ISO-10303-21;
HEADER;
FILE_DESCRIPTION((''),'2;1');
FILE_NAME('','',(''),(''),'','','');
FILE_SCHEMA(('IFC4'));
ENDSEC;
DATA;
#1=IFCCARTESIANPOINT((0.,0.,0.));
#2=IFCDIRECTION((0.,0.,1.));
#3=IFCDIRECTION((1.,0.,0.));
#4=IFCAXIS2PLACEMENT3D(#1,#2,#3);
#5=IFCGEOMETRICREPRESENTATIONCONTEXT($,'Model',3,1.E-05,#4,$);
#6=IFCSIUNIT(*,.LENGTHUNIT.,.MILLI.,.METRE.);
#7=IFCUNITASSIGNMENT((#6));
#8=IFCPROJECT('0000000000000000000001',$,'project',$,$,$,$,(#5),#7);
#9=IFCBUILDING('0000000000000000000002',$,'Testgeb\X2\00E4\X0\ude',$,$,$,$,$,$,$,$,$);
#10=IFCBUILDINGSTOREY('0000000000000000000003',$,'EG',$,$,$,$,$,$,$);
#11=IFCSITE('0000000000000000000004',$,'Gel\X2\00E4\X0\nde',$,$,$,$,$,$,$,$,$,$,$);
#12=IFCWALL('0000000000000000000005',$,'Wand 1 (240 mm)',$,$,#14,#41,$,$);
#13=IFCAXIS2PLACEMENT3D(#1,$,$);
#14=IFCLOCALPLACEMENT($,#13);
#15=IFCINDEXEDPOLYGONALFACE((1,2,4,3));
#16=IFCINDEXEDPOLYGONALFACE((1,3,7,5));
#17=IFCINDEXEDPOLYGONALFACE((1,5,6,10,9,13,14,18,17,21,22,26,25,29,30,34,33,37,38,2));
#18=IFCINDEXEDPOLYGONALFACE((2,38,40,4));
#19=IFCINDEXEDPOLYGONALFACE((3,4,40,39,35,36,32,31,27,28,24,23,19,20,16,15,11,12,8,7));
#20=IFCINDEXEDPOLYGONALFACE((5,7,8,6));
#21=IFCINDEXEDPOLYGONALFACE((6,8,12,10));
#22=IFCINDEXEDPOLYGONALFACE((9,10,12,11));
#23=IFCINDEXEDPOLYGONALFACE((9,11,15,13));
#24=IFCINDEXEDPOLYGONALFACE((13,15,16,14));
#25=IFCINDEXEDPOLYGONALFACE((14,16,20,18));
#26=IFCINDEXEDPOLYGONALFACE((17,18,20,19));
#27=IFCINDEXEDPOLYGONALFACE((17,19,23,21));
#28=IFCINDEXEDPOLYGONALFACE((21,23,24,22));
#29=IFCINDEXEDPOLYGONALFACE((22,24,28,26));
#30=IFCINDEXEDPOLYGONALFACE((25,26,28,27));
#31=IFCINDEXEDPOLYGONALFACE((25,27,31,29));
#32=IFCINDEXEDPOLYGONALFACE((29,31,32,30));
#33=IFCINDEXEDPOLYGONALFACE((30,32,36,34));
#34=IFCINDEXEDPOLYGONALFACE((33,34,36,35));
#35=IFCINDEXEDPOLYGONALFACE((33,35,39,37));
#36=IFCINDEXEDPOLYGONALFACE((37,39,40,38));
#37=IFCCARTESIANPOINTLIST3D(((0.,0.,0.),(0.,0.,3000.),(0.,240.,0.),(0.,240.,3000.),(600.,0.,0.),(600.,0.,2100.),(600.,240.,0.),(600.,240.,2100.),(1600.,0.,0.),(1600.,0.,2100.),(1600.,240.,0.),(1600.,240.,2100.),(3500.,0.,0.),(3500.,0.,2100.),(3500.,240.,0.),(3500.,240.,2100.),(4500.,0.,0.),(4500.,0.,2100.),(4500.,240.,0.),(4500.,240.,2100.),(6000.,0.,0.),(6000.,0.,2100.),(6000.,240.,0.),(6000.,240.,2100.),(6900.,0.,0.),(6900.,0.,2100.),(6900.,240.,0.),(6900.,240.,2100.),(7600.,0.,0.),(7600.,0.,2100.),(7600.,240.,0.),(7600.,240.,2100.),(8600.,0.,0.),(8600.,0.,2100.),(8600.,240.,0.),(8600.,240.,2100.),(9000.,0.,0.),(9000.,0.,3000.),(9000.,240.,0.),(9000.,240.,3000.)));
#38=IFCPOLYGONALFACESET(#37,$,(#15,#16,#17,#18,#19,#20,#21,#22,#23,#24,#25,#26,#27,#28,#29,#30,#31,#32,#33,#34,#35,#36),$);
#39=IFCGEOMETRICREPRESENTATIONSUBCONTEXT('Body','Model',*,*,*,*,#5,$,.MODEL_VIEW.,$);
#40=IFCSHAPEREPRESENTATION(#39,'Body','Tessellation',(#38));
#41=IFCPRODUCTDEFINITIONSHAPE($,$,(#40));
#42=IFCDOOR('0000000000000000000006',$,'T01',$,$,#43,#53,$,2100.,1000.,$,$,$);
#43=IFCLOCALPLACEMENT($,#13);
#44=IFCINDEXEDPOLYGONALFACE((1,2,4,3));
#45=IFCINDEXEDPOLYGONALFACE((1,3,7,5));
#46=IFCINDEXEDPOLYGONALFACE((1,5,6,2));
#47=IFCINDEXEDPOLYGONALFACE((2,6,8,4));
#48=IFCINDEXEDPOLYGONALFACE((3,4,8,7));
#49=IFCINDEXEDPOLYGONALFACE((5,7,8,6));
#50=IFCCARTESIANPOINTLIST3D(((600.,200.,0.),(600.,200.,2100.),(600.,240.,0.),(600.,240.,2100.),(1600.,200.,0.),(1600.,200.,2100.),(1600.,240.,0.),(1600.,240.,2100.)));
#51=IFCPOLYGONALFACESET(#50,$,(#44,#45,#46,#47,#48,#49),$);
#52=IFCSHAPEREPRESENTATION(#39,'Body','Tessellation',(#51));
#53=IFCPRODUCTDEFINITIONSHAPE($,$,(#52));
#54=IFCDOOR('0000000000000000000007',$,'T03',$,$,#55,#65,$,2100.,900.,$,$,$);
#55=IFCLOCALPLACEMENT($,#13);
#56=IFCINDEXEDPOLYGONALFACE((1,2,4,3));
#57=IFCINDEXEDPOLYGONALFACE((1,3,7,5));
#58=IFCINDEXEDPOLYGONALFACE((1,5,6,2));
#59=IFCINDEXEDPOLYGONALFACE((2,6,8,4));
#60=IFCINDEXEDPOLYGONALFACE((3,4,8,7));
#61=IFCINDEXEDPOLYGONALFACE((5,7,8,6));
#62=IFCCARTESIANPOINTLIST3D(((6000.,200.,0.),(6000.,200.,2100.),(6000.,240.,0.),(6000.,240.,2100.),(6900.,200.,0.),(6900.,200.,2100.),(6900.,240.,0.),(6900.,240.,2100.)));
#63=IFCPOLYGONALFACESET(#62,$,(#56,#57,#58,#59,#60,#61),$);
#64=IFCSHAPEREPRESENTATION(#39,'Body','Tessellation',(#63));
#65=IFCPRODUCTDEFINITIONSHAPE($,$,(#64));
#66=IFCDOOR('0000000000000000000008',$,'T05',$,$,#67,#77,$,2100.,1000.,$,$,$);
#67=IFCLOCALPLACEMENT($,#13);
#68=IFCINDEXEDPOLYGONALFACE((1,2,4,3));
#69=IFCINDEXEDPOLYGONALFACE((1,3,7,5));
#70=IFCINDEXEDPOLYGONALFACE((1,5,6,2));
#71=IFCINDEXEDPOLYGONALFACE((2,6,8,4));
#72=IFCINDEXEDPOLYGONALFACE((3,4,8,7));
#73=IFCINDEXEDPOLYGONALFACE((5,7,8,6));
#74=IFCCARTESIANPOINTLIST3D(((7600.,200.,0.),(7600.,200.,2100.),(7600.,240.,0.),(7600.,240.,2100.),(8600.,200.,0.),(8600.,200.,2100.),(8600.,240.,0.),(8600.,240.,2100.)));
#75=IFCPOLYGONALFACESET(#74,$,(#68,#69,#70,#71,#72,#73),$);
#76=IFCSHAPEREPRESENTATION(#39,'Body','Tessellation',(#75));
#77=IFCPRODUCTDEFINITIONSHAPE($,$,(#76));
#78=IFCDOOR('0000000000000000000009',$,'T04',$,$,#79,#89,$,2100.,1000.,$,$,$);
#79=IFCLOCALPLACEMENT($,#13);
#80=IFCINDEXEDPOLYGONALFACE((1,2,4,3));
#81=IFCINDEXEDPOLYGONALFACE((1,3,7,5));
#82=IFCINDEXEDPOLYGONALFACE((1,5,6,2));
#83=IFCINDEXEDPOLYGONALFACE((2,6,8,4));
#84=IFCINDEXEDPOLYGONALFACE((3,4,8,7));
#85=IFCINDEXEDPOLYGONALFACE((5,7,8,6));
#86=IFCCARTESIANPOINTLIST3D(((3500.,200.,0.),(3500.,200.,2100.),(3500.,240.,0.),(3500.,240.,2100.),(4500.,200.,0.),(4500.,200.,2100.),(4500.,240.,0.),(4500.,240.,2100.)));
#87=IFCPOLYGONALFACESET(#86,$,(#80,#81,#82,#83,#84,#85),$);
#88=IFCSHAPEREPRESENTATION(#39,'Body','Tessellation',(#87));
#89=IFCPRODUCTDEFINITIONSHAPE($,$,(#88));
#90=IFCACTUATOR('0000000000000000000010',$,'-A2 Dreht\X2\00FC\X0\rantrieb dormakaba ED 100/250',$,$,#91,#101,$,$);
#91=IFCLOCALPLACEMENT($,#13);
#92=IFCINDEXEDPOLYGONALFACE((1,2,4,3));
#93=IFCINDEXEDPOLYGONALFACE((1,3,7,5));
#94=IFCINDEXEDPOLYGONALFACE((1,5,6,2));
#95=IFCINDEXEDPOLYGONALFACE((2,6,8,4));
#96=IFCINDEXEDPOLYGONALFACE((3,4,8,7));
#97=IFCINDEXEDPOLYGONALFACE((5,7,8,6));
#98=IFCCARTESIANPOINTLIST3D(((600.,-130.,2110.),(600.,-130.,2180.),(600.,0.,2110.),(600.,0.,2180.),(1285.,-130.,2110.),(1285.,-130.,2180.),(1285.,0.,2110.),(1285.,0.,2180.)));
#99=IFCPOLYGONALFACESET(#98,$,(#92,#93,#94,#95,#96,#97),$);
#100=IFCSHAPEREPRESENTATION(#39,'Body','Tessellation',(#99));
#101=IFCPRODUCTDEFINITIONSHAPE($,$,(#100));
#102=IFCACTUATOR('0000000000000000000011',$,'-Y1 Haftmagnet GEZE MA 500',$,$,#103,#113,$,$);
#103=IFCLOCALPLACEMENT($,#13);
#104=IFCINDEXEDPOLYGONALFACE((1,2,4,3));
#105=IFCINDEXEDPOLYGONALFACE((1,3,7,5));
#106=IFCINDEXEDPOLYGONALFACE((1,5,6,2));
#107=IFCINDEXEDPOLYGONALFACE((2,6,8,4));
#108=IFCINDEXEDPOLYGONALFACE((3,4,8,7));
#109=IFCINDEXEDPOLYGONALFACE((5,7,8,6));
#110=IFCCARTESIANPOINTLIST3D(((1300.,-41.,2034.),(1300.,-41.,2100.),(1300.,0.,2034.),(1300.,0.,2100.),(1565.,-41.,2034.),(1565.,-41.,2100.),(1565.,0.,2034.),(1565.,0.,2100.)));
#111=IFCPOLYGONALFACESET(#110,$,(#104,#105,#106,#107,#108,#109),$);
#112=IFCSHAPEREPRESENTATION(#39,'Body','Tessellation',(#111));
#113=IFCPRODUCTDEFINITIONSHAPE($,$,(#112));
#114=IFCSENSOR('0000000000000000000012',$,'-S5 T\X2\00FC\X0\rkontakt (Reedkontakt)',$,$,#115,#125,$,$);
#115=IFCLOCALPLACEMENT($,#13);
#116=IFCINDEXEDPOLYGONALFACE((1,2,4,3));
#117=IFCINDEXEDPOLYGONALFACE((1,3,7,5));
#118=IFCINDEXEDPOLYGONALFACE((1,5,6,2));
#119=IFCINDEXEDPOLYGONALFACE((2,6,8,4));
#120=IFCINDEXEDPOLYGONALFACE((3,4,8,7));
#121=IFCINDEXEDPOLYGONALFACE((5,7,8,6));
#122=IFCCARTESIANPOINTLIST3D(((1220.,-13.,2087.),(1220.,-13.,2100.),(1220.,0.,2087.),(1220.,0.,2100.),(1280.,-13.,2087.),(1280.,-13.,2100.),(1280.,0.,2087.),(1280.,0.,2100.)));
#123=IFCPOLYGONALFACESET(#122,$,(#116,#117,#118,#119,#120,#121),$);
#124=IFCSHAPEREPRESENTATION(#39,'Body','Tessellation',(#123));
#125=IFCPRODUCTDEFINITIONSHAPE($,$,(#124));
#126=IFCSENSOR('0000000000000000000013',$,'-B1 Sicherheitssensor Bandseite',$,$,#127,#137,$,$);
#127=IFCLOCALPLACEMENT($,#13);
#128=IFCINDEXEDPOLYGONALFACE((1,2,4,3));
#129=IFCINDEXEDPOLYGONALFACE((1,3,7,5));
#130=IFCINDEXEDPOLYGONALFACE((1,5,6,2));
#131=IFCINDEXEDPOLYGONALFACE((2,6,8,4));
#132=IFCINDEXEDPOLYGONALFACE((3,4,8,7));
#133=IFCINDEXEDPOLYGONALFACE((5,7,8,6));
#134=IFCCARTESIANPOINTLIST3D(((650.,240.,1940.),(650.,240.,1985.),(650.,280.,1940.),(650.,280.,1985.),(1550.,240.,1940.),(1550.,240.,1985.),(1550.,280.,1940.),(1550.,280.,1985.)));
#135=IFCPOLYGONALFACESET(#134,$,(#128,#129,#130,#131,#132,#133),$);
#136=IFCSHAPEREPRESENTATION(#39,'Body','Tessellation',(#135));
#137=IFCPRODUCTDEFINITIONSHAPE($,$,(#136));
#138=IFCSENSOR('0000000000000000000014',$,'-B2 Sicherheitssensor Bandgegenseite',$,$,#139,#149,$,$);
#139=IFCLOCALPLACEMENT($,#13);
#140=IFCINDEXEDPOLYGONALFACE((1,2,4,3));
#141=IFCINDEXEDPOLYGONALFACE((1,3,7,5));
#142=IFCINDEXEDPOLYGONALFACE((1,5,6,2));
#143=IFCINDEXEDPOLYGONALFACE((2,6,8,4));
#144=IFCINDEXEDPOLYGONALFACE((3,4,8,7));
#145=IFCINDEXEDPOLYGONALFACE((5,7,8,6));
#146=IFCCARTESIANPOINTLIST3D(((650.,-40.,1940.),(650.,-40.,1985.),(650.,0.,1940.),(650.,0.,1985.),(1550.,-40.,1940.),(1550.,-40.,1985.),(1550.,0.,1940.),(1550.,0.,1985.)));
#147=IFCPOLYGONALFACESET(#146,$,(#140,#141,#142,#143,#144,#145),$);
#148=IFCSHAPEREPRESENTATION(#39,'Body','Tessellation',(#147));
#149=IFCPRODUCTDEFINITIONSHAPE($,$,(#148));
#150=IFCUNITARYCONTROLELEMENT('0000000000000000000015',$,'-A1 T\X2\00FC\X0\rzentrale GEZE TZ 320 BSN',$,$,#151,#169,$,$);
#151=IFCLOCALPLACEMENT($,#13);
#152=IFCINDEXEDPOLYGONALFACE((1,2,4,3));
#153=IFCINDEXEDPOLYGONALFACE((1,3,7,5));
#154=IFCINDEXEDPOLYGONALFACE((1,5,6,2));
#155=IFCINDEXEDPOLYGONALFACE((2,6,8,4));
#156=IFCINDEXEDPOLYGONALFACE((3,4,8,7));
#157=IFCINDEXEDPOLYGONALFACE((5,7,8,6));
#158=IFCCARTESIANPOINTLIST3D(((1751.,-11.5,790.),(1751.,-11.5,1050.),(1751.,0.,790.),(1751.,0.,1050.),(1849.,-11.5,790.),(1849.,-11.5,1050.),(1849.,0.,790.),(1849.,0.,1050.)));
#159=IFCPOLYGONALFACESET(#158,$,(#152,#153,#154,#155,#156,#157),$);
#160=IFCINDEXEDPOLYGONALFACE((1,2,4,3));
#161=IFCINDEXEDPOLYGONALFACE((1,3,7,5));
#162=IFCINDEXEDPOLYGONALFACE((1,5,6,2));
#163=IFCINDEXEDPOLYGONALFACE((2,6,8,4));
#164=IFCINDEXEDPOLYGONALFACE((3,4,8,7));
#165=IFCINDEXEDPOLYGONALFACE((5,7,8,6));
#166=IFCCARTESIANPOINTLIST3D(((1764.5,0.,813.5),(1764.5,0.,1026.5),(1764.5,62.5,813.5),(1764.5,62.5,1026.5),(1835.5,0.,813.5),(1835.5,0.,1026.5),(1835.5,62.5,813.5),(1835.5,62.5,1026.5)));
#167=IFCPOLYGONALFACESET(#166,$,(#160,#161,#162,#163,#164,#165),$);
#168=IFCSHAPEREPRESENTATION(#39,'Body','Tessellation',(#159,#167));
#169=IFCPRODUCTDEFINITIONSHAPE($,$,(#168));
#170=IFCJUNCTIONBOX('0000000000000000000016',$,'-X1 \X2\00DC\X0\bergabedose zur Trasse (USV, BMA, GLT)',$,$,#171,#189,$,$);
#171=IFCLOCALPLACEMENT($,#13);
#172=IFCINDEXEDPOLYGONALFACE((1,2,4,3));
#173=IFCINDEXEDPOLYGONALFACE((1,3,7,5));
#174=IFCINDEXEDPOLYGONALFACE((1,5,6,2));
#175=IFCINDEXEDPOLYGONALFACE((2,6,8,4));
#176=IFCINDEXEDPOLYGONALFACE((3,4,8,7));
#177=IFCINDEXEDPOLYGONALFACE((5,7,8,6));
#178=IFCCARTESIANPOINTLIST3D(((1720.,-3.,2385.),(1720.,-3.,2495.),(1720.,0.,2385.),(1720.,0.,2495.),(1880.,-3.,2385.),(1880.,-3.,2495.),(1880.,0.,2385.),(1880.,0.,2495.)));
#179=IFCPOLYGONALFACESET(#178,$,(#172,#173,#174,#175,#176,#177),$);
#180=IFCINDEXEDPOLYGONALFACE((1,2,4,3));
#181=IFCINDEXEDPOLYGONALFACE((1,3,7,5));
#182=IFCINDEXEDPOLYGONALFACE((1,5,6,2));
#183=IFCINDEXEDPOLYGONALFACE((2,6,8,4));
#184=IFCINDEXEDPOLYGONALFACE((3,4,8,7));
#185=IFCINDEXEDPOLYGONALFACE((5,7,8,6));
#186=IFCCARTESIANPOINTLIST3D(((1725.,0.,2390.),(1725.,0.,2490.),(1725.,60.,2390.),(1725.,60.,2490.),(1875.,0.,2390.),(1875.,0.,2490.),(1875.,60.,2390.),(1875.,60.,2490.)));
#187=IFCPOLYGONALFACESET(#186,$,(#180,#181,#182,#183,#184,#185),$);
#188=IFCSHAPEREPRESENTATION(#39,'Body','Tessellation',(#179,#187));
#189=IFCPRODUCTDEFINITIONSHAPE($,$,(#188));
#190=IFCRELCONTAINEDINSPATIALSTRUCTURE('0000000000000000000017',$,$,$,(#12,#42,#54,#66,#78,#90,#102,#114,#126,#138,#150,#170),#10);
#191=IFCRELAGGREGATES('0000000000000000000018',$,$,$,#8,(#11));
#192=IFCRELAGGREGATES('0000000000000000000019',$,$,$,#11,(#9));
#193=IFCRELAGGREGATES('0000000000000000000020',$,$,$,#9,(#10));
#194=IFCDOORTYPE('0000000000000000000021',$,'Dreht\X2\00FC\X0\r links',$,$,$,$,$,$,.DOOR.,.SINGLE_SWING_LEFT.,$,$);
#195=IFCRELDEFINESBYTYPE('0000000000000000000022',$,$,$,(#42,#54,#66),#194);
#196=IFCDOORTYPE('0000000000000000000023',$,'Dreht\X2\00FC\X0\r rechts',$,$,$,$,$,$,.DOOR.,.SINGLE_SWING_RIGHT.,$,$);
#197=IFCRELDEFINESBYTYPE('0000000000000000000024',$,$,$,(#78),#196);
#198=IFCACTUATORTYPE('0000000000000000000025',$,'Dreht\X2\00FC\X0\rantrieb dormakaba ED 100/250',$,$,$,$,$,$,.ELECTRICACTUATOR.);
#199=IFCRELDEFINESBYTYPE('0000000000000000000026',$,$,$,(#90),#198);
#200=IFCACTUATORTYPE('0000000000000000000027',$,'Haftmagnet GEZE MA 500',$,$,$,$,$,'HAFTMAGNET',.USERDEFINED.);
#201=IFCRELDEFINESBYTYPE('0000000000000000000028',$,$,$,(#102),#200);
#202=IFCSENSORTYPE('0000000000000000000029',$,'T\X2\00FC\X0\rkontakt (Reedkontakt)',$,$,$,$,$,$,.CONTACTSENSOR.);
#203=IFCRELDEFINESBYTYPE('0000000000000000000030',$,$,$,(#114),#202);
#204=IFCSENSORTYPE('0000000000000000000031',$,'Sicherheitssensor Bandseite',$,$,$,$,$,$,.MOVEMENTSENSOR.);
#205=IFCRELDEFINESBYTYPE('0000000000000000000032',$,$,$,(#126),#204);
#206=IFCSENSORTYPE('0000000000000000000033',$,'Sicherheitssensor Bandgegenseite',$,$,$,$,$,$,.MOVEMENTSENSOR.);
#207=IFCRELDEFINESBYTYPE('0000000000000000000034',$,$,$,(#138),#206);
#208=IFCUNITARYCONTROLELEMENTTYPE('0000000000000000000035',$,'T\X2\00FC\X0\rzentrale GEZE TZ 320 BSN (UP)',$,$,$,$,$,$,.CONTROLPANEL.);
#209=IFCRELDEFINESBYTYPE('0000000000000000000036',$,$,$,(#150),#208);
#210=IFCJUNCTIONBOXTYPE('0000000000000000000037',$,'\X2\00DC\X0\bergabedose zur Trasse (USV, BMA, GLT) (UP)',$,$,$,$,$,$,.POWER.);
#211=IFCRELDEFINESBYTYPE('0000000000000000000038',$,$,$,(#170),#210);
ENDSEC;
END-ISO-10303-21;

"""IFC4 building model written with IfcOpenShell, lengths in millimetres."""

from ifc_helpers import new_model, si_unit, frame, frame_2d, origin_with_axes, place, context, subcontext, project, spatial, rectangle, extrude, type_object, element, fill, save


model = new_model("IFC4")

# Units and contexts
model_context = context("Model", 3, precision=1e-05, world=origin_with_axes())
body_context = subcontext(model_context, "Body", "Model", "MODEL_VIEW")
ifc_project = project(units=[si_unit("LENGTHUNIT", "METRE", prefix="MILLI")], contexts=[model_context])

# Site, building, storey
site = spatial("IfcSite", under=ifc_project, Name="Gelände")
building = spatial("IfcBuilding", under=site, Name="Testgebäude")
storey = spatial("IfcBuildingStorey", under=building, Name="EG")

# Wall, openings, doors
wall_placement = place(None, origin_with_axes())
wall = element("IfcWall", 1, at=wall_placement, inside=storey, Name="Wand 1 (240 mm)", context=body_context, shape_type="SweptSolid", body=[
    extrude(rectangle(XDim=9000.0, YDim=240.0, at=frame_2d((4500.0, 120.0))), None, (0.0, 0.0, 1.0), 3000.0),
])
opening_1_placement = place(None, frame((600.0, 0.0, 0.0), z_axis=(0.0, 0.0, 1.0), x_axis=(1.0, 0.0, 0.0)))
opening_1 = element("IfcOpeningElement", 2, at=opening_1_placement, cuts=wall, context=body_context, shape_type="SweptSolid", body=[
    extrude(rectangle(XDim=1000.0, YDim=240.0, at=frame_2d((500.0, 120.0))), None, (0.0, 0.0, 1.0), 2100.0),
])
opening_2_placement = place(None, frame((3500.0, 0.0, 0.0), z_axis=(0.0, 0.0, 1.0), x_axis=(1.0, 0.0, 0.0)))
opening_2 = element("IfcOpeningElement", 3, at=opening_2_placement, cuts=wall, context=body_context, shape_type="SweptSolid", body=[
    extrude(rectangle(XDim=1000.0, YDim=240.0, at=frame_2d((500.0, 120.0))), None, (0.0, 0.0, 1.0), 2100.0),
])
opening_3_placement = place(None, frame((6000.0, 0.0, 0.0), z_axis=(0.0, 0.0, 1.0), x_axis=(1.0, 0.0, 0.0)))
opening_3 = element("IfcOpeningElement", 4, at=opening_3_placement, cuts=wall, context=body_context, shape_type="SweptSolid", body=[
    extrude(rectangle(XDim=900.0, YDim=240.0, at=frame_2d((450.0, 120.0))), None, (0.0, 0.0, 1.0), 2100.0),
])
opening_4_placement = place(None, frame((7600.0, 0.0, 0.0), z_axis=(0.0, 0.0, 1.0), x_axis=(1.0, 0.0, 0.0)))
opening_4 = element("IfcOpeningElement", 5, at=opening_4_placement, cuts=wall, context=body_context, shape_type="SweptSolid", body=[
    extrude(rectangle(XDim=1000.0, YDim=240.0, at=frame_2d((500.0, 120.0))), None, (0.0, 0.0, 1.0), 2100.0),
])
door_type_1 = type_object("IfcDoorType", Name="Drehtür links", OperationType="SINGLE_SWING_LEFT", PredefinedType="DOOR")
door_1_placement = place(opening_1_placement, origin_with_axes())
door_1 = element("IfcDoor", 6, at=door_1_placement, inside=storey, type_object=door_type_1, Name="T01", OverallHeight=2100.0, OverallWidth=1000.0, context=body_context, shape_type="SweptSolid", body=[
    extrude(rectangle(XDim=1000.0, YDim=40.0, at=frame_2d((500.0, 20.0))), frame((0.0, 200.0, 0.0)), (0.0, 0.0, 1.0), 2100.0),
])
fill(opening_1, door_1)
door_2_placement = place(opening_3_placement, origin_with_axes())
door_2 = element("IfcDoor", 7, at=door_2_placement, inside=storey, type_object=door_type_1, Name="T03", OverallHeight=2100.0, OverallWidth=900.0, context=body_context, shape_type="SweptSolid", body=[
    extrude(rectangle(XDim=900.0, YDim=40.0, at=frame_2d((450.0, 20.0))), frame((0.0, 200.0, 0.0)), (0.0, 0.0, 1.0), 2100.0),
])
fill(opening_3, door_2)
door_3_placement = place(opening_4_placement, origin_with_axes())
door_3 = element("IfcDoor", 8, at=door_3_placement, inside=storey, type_object=door_type_1, Name="T05", OverallHeight=2100.0, OverallWidth=1000.0, context=body_context, shape_type="SweptSolid", body=[
    extrude(rectangle(XDim=1000.0, YDim=40.0, at=frame_2d((500.0, 20.0))), frame((0.0, 200.0, 0.0)), (0.0, 0.0, 1.0), 2100.0),
])
fill(opening_4, door_3)
door_type_2 = type_object("IfcDoorType", Name="Drehtür rechts", OperationType="SINGLE_SWING_RIGHT", PredefinedType="DOOR")
door_4_placement = place(opening_2_placement, origin_with_axes())
door_4 = element("IfcDoor", 9, at=door_4_placement, inside=storey, type_object=door_type_2, Name="T04", OverallHeight=2100.0, OverallWidth=1000.0, context=body_context, shape_type="SweptSolid", body=[
    extrude(rectangle(XDim=1000.0, YDim=40.0, at=frame_2d((500.0, 20.0))), frame((0.0, 200.0, 0.0)), (0.0, 0.0, 1.0), 2100.0),
])
fill(opening_2, door_4)

# Actuators
actuator_type_1 = type_object("IfcActuatorType", Name="Drehtürantrieb dormakaba ED 100/250", PredefinedType="ELECTRICACTUATOR")
actuator_1_placement = place(None, frame((600.0, -130.0, 2110.0), z_axis=(0.0, 0.0, 1.0), x_axis=(1.0, 0.0, 0.0)))
element("IfcActuator", 10, at=actuator_1_placement, inside=storey, type_object=actuator_type_1, Name="-A2 Drehtürantrieb dormakaba ED 100/250", context=body_context, shape_type="SweptSolid", body=[
    extrude(rectangle(XDim=685.0, YDim=130.0, at=frame_2d((342.5, 65.0))), None, (0.0, 0.0, 1.0), 70.0),
])
actuator_type_2 = type_object("IfcActuatorType", Name="Haftmagnet GEZE MA 500", ElementType="HAFTMAGNET", PredefinedType="USERDEFINED")
actuator_2_placement = place(None, frame((1300.0, -41.0, 2034.0), z_axis=(0.0, 0.0, 1.0), x_axis=(1.0, 0.0, 0.0)))
element("IfcActuator", 11, at=actuator_2_placement, inside=storey, type_object=actuator_type_2, Name="-Y1 Haftmagnet GEZE MA 500", context=body_context, shape_type="SweptSolid", body=[
    extrude(rectangle(XDim=265.0, YDim=41.0, at=frame_2d((132.5, 20.5))), None, (0.0, 0.0, 1.0), 66.0),
])

# Sensors
sensor_type_1 = type_object("IfcSensorType", Name="Türkontakt (Reedkontakt)", PredefinedType="CONTACTSENSOR")
sensor_1_placement = place(None, frame((1220.0, -13.0, 2087.0), z_axis=(0.0, 0.0, 1.0), x_axis=(1.0, 0.0, 0.0)))
element("IfcSensor", 12, at=sensor_1_placement, inside=storey, type_object=sensor_type_1, Name="-S5 Türkontakt (Reedkontakt)", context=body_context, shape_type="SweptSolid", body=[
    extrude(rectangle(XDim=60.0, YDim=13.0, at=frame_2d((30.0, 6.5))), None, (0.0, 0.0, 1.0), 13.0),
])
sensor_type_2 = type_object("IfcSensorType", Name="Sicherheitssensor Bandseite", PredefinedType="MOVEMENTSENSOR")
sensor_2_placement = place(None, frame((650.0, 240.0, 1940.0), z_axis=(0.0, 0.0, 1.0), x_axis=(1.0, 0.0, 0.0)))
element("IfcSensor", 13, at=sensor_2_placement, inside=storey, type_object=sensor_type_2, Name="-B1 Sicherheitssensor Bandseite", context=body_context, shape_type="SweptSolid", body=[
    extrude(rectangle(XDim=900.0, YDim=40.0, at=frame_2d((450.0, 20.0))), None, (0.0, 0.0, 1.0), 45.0),
])
sensor_type_3 = type_object("IfcSensorType", Name="Sicherheitssensor Bandgegenseite", PredefinedType="MOVEMENTSENSOR")
sensor_3_placement = place(None, frame((650.0, -40.0, 1940.0), z_axis=(0.0, 0.0, 1.0), x_axis=(1.0, 0.0, 0.0)))
element("IfcSensor", 14, at=sensor_3_placement, inside=storey, type_object=sensor_type_3, Name="-B2 Sicherheitssensor Bandgegenseite", context=body_context, shape_type="SweptSolid", body=[
    extrude(rectangle(XDim=900.0, YDim=40.0, at=frame_2d((450.0, 20.0))), None, (0.0, 0.0, 1.0), 45.0),
])

# Unitary control element
unitary_control_element_type = type_object("IfcUnitaryControlElementType", Name="Türzentrale GEZE TZ 320 BSN (UP)", PredefinedType="CONTROLPANEL")
unitary_control_element_placement = place(None, frame((1751.0, -11.5, 790.0), z_axis=(0.0, 0.0, 1.0), x_axis=(1.0, 0.0, 0.0)))
element("IfcUnitaryControlElement", 15, at=unitary_control_element_placement, inside=storey, type_object=unitary_control_element_type, Name="-A1 Türzentrale GEZE TZ 320 BSN", context=body_context, shape_type="SweptSolid", body=[
    extrude(rectangle(XDim=98.0, YDim=11.5, at=frame_2d((49.0, 5.8))), None, (0.0, 0.0, 1.0), 260.0),
    extrude(rectangle(XDim=71.0, YDim=62.5, at=frame_2d((35.5, 31.2))), frame((13.5, 11.5, 23.5), z_axis=(0.0, 0.0, 1.0), x_axis=(1.0, 0.0, 0.0)), (0.0, 0.0, 1.0), 213.0),
])

# Junction box
junction_box_type = type_object("IfcJunctionBoxType", Name="Übergabedose zur Trasse (USV, BMA, GLT) (UP)", PredefinedType="POWER")
junction_box_placement = place(None, frame((1720.0, -3.0, 2385.0), z_axis=(0.0, 0.0, 1.0), x_axis=(1.0, 0.0, 0.0)))
element("IfcJunctionBox", 16, at=junction_box_placement, inside=storey, type_object=junction_box_type, Name="-X1 Übergabedose zur Trasse (USV, BMA, GLT)", context=body_context, shape_type="SweptSolid", body=[
    extrude(rectangle(XDim=160.0, YDim=3.0, at=frame_2d((80.0, 1.5))), None, (0.0, 0.0, 1.0), 110.0),
    extrude(rectangle(XDim=150.0, YDim=60.0, at=frame_2d((75.0, 30.0))), frame((5.0, 3.0, 5.0), z_axis=(0.0, 0.0, 1.0), x_axis=(1.0, 0.0, 0.0)), (0.0, 0.0, 1.0), 100.0),
])

save(model, "model.ifc")
